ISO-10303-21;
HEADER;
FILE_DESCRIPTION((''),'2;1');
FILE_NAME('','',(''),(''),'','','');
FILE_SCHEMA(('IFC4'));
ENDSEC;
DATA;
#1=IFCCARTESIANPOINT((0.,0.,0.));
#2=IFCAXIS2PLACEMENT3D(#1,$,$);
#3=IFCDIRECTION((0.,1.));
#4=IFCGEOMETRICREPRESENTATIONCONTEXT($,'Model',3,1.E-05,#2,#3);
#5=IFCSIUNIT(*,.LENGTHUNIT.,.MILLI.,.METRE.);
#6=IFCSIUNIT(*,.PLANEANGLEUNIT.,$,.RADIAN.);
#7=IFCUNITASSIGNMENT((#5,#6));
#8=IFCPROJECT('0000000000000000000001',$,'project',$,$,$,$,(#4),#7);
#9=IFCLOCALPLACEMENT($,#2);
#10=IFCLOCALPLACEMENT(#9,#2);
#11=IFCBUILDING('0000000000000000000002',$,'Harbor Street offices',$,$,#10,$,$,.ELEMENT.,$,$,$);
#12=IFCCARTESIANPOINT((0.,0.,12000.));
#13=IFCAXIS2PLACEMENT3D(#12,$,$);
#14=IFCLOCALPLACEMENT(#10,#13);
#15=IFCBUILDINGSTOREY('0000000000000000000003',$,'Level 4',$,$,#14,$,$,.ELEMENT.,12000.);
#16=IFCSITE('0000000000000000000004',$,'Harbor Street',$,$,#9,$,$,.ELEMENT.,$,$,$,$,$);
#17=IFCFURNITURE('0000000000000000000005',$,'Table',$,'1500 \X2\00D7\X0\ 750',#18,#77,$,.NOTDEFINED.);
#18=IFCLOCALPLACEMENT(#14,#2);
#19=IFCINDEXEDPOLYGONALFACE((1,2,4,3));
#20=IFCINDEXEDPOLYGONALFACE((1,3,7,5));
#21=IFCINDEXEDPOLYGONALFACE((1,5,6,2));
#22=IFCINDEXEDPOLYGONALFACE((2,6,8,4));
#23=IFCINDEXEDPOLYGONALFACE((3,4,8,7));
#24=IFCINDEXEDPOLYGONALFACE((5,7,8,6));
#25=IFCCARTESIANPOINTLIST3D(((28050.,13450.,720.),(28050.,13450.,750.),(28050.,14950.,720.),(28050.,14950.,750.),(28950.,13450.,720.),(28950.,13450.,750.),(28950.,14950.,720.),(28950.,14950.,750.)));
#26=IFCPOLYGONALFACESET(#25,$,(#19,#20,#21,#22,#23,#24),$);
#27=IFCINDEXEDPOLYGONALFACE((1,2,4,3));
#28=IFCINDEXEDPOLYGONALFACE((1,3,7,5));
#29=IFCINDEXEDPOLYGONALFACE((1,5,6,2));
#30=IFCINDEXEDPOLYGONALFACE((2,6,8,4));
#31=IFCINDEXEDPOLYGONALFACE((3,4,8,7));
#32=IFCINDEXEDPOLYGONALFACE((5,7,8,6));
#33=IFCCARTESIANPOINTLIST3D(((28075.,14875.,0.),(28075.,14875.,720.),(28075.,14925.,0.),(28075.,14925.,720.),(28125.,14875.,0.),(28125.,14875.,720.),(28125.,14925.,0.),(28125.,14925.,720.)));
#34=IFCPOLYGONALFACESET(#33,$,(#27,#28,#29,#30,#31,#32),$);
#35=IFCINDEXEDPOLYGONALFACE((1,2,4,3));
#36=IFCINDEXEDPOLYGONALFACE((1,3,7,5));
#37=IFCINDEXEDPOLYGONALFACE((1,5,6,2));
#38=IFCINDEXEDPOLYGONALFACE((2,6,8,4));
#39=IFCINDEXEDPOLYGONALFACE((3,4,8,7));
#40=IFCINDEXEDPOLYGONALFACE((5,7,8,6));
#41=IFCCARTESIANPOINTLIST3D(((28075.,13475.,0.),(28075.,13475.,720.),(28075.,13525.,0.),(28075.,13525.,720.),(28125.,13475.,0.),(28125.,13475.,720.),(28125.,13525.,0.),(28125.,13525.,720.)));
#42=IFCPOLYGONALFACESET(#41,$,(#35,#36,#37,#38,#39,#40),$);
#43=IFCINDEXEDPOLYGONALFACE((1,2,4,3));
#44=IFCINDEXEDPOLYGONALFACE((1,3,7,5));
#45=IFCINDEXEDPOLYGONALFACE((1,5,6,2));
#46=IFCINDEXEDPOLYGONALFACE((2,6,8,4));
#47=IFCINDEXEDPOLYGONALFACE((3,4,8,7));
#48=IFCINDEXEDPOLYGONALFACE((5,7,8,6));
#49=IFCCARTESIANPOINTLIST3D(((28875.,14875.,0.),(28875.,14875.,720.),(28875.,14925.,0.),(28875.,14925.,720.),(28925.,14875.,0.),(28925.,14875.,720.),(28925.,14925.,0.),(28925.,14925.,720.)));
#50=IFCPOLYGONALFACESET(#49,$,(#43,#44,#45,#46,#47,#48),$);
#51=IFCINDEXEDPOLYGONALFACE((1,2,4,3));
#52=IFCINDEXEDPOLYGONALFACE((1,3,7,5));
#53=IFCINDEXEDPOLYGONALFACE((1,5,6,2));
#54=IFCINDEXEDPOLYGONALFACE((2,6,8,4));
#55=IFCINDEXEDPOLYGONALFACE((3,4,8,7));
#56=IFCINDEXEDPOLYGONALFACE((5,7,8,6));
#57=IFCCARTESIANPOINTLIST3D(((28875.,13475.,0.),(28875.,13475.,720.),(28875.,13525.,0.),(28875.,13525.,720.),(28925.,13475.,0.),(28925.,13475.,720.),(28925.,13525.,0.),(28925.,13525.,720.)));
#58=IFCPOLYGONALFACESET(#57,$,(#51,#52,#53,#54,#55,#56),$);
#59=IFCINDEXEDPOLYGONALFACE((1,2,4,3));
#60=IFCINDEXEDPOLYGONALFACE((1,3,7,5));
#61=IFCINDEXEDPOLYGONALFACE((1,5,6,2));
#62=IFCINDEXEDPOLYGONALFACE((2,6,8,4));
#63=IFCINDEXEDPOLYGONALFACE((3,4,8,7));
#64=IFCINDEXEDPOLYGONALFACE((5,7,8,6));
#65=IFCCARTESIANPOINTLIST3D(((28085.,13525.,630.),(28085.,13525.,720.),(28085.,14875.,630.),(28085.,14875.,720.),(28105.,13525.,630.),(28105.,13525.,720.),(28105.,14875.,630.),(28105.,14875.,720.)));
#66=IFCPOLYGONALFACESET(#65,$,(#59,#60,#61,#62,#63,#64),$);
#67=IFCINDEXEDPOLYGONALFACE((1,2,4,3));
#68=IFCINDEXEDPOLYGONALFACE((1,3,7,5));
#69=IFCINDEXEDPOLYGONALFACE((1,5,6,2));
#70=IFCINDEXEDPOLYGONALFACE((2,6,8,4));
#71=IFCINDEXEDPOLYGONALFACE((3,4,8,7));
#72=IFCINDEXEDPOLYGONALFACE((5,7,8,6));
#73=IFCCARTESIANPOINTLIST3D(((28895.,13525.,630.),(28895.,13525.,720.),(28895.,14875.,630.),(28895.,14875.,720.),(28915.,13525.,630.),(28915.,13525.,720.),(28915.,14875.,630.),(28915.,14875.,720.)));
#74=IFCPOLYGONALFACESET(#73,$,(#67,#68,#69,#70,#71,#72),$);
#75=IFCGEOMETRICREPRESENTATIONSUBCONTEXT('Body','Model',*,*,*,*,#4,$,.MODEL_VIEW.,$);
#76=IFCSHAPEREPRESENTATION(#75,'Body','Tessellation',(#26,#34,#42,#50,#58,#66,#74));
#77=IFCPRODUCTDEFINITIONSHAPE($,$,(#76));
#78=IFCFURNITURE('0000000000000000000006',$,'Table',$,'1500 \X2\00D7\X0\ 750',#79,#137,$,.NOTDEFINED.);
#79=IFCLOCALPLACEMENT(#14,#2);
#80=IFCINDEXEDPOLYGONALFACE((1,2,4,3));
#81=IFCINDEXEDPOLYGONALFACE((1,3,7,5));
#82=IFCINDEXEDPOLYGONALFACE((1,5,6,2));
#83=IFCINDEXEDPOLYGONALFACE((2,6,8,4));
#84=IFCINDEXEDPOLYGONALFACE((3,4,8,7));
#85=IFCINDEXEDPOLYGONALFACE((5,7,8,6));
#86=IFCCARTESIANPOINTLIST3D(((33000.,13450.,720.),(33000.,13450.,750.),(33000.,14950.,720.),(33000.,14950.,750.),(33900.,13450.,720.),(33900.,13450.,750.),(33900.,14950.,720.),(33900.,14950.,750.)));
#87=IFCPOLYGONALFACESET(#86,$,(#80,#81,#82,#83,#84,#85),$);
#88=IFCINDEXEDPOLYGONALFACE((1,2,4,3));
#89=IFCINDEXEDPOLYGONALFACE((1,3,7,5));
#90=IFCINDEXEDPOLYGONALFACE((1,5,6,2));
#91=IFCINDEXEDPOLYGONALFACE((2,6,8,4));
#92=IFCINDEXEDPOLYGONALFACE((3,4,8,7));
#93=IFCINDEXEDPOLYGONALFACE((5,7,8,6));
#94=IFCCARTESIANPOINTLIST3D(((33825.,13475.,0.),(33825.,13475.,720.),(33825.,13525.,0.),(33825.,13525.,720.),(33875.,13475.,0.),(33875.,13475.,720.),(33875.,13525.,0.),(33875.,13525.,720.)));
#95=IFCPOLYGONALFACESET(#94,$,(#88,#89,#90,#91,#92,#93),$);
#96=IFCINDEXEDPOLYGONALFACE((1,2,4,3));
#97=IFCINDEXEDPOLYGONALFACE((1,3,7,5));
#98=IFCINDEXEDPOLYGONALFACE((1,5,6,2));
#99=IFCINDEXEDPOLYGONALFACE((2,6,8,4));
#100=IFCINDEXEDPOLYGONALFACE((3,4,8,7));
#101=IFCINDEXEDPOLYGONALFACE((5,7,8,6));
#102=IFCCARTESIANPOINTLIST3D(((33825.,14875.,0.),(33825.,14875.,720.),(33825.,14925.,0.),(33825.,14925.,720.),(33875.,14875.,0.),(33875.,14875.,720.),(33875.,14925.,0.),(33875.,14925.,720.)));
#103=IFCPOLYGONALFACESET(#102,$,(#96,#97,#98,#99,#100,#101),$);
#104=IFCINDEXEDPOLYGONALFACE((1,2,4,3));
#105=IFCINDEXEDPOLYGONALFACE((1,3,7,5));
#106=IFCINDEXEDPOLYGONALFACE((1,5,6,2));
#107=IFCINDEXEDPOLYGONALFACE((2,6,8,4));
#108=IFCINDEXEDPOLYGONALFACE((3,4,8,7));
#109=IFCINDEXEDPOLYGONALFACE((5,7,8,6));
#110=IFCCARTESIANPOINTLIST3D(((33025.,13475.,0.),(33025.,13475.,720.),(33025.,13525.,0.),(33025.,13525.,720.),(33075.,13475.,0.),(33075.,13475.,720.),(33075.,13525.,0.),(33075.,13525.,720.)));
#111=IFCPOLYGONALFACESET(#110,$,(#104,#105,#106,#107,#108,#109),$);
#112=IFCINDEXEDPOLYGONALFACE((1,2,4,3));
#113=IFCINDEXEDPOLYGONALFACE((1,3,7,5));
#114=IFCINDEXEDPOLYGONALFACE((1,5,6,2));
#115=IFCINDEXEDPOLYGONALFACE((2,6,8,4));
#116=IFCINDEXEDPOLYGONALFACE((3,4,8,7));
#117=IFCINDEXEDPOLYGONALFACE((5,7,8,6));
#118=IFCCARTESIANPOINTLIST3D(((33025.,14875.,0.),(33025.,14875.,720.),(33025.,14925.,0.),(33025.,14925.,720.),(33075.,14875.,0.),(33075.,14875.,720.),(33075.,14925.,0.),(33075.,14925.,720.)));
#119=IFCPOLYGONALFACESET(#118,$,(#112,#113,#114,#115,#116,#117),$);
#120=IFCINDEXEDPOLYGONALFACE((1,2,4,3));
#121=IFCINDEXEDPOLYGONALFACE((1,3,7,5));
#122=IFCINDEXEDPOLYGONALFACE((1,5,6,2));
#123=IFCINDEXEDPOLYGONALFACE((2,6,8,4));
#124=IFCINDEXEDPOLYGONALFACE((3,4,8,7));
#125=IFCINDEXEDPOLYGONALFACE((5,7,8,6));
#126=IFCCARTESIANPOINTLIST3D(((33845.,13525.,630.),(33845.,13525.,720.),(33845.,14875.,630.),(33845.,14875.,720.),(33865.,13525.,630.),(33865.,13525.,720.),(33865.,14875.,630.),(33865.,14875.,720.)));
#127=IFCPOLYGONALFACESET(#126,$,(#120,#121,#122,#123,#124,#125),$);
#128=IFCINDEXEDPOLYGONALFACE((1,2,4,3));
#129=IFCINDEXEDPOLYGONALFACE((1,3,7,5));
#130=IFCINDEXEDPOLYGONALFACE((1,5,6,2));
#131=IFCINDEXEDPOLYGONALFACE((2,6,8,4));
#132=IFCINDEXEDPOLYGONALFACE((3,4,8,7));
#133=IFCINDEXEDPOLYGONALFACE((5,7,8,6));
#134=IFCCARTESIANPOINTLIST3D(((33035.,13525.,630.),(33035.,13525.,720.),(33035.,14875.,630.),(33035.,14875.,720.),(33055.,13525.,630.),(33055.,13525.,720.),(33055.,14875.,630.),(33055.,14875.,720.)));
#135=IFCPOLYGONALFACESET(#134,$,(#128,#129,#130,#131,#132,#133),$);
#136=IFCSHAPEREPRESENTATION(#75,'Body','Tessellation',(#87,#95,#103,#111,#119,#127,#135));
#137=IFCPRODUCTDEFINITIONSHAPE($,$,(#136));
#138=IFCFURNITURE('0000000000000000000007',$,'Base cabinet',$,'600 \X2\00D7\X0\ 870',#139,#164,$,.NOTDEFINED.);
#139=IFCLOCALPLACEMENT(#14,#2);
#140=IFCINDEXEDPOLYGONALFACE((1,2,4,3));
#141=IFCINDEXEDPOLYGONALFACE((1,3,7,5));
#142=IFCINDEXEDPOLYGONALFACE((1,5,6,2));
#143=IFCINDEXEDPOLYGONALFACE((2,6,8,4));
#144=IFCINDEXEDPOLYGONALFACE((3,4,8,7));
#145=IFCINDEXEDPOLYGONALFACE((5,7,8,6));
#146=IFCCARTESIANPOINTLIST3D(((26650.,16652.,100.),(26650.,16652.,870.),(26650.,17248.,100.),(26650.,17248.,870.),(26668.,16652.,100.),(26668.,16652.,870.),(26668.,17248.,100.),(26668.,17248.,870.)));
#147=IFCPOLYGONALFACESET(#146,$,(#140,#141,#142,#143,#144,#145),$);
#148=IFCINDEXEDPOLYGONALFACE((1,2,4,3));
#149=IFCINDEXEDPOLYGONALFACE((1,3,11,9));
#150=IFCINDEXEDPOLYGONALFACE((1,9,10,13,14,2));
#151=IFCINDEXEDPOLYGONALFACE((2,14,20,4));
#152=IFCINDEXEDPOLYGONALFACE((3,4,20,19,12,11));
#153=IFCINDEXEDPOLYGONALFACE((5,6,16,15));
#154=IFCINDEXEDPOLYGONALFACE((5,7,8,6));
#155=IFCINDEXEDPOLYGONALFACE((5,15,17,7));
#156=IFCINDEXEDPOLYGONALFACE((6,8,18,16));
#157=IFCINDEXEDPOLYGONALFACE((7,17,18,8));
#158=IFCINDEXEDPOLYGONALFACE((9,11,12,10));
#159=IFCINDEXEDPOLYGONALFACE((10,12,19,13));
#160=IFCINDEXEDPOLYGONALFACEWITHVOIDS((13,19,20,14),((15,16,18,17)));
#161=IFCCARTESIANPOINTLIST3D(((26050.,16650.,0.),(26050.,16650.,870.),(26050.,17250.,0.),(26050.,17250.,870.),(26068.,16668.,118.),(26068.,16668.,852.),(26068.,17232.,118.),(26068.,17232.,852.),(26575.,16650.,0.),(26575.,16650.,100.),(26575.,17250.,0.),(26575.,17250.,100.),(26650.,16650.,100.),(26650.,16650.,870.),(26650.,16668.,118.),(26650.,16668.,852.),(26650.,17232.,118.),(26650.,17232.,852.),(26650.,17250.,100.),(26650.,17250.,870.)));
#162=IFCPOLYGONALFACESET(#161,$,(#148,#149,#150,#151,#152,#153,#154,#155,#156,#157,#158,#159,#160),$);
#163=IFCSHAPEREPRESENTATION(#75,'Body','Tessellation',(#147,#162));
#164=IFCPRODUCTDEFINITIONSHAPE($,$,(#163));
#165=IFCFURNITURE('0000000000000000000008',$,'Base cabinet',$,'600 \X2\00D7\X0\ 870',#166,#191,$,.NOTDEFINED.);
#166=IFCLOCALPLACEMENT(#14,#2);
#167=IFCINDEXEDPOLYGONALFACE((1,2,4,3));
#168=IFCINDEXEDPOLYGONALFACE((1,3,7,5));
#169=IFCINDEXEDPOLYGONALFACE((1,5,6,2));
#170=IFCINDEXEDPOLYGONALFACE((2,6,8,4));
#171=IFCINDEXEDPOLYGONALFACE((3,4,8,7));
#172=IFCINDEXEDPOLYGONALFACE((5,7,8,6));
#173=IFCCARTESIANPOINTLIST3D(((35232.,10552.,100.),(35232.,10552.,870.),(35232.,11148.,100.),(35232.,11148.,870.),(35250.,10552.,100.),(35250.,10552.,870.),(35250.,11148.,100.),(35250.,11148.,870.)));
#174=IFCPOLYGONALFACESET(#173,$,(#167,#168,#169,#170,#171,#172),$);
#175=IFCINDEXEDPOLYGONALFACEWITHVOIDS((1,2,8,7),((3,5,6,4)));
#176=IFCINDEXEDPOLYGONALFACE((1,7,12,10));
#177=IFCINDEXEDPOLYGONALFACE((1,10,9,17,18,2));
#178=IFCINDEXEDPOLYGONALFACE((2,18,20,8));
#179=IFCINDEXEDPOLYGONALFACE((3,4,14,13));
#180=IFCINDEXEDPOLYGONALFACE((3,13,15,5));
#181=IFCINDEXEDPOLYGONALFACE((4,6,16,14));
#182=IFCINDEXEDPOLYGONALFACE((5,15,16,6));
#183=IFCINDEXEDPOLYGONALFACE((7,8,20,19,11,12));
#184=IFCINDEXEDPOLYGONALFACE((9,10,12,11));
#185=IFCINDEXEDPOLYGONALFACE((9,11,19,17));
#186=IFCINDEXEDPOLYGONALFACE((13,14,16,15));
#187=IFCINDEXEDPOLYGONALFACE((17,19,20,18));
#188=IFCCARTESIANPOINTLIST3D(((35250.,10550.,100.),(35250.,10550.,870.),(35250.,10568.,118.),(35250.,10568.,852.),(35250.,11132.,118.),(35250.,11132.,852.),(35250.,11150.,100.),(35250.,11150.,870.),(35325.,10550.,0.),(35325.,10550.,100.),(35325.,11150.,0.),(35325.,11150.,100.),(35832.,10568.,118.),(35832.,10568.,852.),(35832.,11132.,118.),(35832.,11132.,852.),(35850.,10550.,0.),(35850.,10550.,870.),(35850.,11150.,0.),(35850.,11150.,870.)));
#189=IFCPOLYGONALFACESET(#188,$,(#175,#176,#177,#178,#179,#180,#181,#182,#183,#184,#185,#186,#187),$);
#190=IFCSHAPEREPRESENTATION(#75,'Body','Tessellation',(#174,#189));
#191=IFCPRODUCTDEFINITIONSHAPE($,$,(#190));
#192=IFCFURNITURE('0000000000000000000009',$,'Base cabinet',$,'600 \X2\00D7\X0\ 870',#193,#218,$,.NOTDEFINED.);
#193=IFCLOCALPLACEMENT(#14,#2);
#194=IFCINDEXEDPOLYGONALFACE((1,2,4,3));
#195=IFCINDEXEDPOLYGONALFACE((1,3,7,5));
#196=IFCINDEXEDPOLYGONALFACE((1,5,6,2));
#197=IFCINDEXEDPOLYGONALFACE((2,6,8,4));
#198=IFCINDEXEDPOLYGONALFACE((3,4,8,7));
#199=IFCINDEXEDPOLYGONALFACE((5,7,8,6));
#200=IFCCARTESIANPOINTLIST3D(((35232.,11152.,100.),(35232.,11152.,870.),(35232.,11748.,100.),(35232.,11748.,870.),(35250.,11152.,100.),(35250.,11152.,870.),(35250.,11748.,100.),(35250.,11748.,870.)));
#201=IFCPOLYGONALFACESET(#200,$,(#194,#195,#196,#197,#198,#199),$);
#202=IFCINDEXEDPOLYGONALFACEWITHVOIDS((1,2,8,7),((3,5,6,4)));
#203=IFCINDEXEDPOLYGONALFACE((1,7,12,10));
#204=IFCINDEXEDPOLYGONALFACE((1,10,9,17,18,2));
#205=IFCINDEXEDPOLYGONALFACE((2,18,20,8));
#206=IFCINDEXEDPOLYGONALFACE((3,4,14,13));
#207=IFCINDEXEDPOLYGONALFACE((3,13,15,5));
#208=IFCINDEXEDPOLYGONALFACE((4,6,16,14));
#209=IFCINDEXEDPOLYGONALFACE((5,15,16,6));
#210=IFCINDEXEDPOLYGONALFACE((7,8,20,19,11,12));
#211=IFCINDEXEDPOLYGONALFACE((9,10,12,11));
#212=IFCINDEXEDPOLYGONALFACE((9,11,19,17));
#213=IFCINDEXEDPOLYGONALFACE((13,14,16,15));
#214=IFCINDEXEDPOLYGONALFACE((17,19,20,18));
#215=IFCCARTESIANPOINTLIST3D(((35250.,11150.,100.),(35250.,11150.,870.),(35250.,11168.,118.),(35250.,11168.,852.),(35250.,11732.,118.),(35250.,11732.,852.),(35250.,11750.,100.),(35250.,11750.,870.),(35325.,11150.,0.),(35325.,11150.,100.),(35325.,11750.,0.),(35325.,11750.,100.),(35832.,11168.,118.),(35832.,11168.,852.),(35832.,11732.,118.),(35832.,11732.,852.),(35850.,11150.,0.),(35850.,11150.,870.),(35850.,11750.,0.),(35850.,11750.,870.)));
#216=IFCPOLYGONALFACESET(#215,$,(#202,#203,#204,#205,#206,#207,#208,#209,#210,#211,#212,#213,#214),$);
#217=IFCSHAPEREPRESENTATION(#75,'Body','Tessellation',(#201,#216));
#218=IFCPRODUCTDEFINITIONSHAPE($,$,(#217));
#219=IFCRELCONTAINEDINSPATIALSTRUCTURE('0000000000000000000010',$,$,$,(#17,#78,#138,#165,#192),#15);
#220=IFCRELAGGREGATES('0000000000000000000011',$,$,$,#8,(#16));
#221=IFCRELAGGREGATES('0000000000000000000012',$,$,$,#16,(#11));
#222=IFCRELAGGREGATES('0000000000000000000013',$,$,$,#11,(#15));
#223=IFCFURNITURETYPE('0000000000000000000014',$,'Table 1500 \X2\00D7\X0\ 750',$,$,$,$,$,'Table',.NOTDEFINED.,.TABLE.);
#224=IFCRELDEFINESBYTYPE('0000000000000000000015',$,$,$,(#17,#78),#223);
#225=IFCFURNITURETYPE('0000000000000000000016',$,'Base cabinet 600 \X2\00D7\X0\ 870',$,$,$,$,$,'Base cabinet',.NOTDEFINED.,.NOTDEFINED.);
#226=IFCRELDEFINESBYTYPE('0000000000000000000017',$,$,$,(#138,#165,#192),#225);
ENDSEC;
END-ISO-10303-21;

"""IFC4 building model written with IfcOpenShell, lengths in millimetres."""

from ifc_helpers import new_model, entity, si_unit, direction, frame, origin, place, context, subcontext, project, spatial, polyline, outline, extrude, source, transform, mapped, type_object, type_shapes, element, save


model = new_model("IFC4")

# Units and contexts
model_context = context("Model", 3, precision=1e-05, world=origin(), true_north=direction((0.0, 1.0)))
body_context = subcontext(model_context, "Body", "Model", "MODEL_VIEW")
ifc_project = project(units=[si_unit("LENGTHUNIT", "METRE", prefix="MILLI"), si_unit("PLANEANGLEUNIT", "RADIAN")], contexts=[model_context])

# Site, building, storey
site_placement = place(None, origin())
site = spatial("IfcSite", under=ifc_project, at=site_placement, Name="Harbor Street", CompositionType="ELEMENT")
building_placement = place(site_placement, origin())
building = spatial("IfcBuilding", under=site, at=building_placement, Name="Harbor Street offices", CompositionType="ELEMENT")
storey_placement = place(building_placement, frame((0.0, 0.0, 12000.0)))
storey = spatial("IfcBuildingStorey", under=building, at=storey_placement, Name="Level 4", CompositionType="ELEMENT", Elevation=12000.0)

# Furniture
furniture_type_1 = type_object("IfcFurnitureType", Name="Table 1500 × 750", ElementType="Table", AssemblyPlace="NOTDEFINED", PredefinedType="TABLE")
shared_shape_1 = source(origin(), body_context, "Body", "SweptSolid", [
    extrude(outline(polyline([(-750.0, -450.0), (750.0, -450.0), (750.0, 450.0), (-750.0, 450.0), (-750.0, -450.0)])), frame((0.0, 0.0, 720.0)), (0.0, 0.0, 1.0), 30.0),
    extrude(outline(polyline([(-725.0, -425.0), (-675.0, -425.0), (-675.0, -375.0), (-725.0, -375.0), (-725.0, -425.0)])), origin(), (0.0, 0.0, 1.0), 720.0),
    extrude(outline(polyline([(675.0, -425.0), (725.0, -425.0), (725.0, -375.0), (675.0, -375.0), (675.0, -425.0)])), origin(), (0.0, 0.0, 1.0), 720.0),
    extrude(outline(polyline([(-725.0, 375.0), (-675.0, 375.0), (-675.0, 425.0), (-725.0, 425.0), (-725.0, 375.0)])), origin(), (0.0, 0.0, 1.0), 720.0),
    extrude(outline(polyline([(675.0, 375.0), (725.0, 375.0), (725.0, 425.0), (675.0, 425.0), (675.0, 375.0)])), origin(), (0.0, 0.0, 1.0), 720.0),
    extrude(outline(polyline([(-675.0, -415.0), (675.0, -415.0), (675.0, -395.0), (-675.0, -395.0), (-675.0, -415.0)])), frame((0.0, 0.0, 630.0)), (0.0, 0.0, 1.0), 90.0),
    extrude(outline(polyline([(-675.0, 395.0), (675.0, 395.0), (675.0, 415.0), (-675.0, 415.0), (-675.0, 395.0)])), frame((0.0, 0.0, 630.0)), (0.0, 0.0, 1.0), 90.0),
])
type_shapes(furniture_type_1, [shared_shape_1])
for number, where, z_axis, x_axis, name in (
    (1, (28500.0, 14200.0, 0.0), (0.0, 0.0, 1.0), (0.0, -1.0, 0.0), "Table"),
    (2, (33450.0, 14200.0, 0.0), (0.0, 0.0, 1.0), (0.0, 1.0, 0.0), "Table"),
):
    element("IfcFurniture", number, at=place(storey_placement, frame(where, z_axis=z_axis, x_axis=x_axis)), inside=storey, type_object=furniture_type_1, Name=name, ObjectType="1500 × 750", PredefinedType="NOTDEFINED", context=body_context, shape_type="MappedRepresentation", body=[
        mapped(shared_shape_1, transform((0.0, 0.0, 0.0))),
    ])
furniture_type_2 = type_object("IfcFurnitureType", Name="Base cabinet 600 × 870", ElementType="Base cabinet", AssemblyPlace="NOTDEFINED", PredefinedType="NOTDEFINED")
cartesian_point_1 = entity("IfcCartesianPoint", [-300.0, 0.0])
cartesian_point_2 = entity("IfcCartesianPoint", [-282.0, -1.0])
cartesian_point_3 = entity("IfcCartesianPoint", [-301.0, -1.0])
shared_shape_2 = source(origin(), body_context, "Body", "SolidModel", [
    extrude(outline(polyline([(-298.0, -18.0), (298.0, -18.0), (298.0, 0.0), (-298.0, 0.0), (-298.0, -18.0)])), frame((0.0, 0.0, 100.0)), (0.0, 0.0, 1.0), 770.0),
    entity("IfcCsgSolid", entity("IfcBooleanResult", "DIFFERENCE", entity("IfcBooleanResult", "DIFFERENCE", entity("IfcExtrudedAreaSolid", entity("IfcArbitraryClosedProfileDef", "AREA", None, entity("IfcPolyline", [cartesian_point_1, entity("IfcCartesianPoint", [300.0, 0.0]), entity("IfcCartesianPoint", [300.0, 600.0]), entity("IfcCartesianPoint", [-300.0, 600.0]), cartesian_point_1])), entity("IfcAxis2Placement3D", entity("IfcCartesianPoint", [0.0, 0.0, 0.0])), entity("IfcDirection", [0.0, 0.0, 1.0]), 870.0), entity("IfcExtrudedAreaSolid", entity("IfcArbitraryClosedProfileDef", "AREA", None, entity("IfcPolyline", [cartesian_point_2, entity("IfcCartesianPoint", [282.0, -1.0]), entity("IfcCartesianPoint", [282.0, 582.0]), entity("IfcCartesianPoint", [-282.0, 582.0]), cartesian_point_2])), entity("IfcAxis2Placement3D", entity("IfcCartesianPoint", [0.0, 0.0, 118.0])), entity("IfcDirection", [0.0, 0.0, 1.0]), 734.0)), entity("IfcExtrudedAreaSolid", entity("IfcArbitraryClosedProfileDef", "AREA", None, entity("IfcPolyline", [cartesian_point_3, entity("IfcCartesianPoint", [301.0, -1.0]), entity("IfcCartesianPoint", [301.0, 75.0]), entity("IfcCartesianPoint", [-301.0, 75.0]), cartesian_point_3])), entity("IfcAxis2Placement3D", entity("IfcCartesianPoint", [0.0, 0.0, -1.0])), entity("IfcDirection", [0.0, 0.0, 1.0]), 101.0))),
])
type_shapes(furniture_type_2, [shared_shape_2])
for number, where, z_axis, x_axis, name in (
    (3, (26650.0, 16950.0, 0.0), (0.0, 0.0, 1.0), (0.0, 1.0, 0.0), "Base cabinet"),
    (4, (35250.0, 10850.0, 0.0), (0.0, 0.0, 1.0), (0.0, -1.0, 0.0), "Base cabinet"),
    (5, (35250.0, 11450.0, 0.0), (0.0, 0.0, 1.0), (0.0, -1.0, 0.0), "Base cabinet"),
):
    element("IfcFurniture", number, at=place(storey_placement, frame(where, z_axis=z_axis, x_axis=x_axis)), inside=storey, type_object=furniture_type_2, Name=name, ObjectType="600 × 870", PredefinedType="NOTDEFINED", context=body_context, shape_type="MappedRepresentation", body=[
        mapped(shared_shape_2, transform((0.0, 0.0, 0.0))),
    ])

save(model, "model.ifc")
